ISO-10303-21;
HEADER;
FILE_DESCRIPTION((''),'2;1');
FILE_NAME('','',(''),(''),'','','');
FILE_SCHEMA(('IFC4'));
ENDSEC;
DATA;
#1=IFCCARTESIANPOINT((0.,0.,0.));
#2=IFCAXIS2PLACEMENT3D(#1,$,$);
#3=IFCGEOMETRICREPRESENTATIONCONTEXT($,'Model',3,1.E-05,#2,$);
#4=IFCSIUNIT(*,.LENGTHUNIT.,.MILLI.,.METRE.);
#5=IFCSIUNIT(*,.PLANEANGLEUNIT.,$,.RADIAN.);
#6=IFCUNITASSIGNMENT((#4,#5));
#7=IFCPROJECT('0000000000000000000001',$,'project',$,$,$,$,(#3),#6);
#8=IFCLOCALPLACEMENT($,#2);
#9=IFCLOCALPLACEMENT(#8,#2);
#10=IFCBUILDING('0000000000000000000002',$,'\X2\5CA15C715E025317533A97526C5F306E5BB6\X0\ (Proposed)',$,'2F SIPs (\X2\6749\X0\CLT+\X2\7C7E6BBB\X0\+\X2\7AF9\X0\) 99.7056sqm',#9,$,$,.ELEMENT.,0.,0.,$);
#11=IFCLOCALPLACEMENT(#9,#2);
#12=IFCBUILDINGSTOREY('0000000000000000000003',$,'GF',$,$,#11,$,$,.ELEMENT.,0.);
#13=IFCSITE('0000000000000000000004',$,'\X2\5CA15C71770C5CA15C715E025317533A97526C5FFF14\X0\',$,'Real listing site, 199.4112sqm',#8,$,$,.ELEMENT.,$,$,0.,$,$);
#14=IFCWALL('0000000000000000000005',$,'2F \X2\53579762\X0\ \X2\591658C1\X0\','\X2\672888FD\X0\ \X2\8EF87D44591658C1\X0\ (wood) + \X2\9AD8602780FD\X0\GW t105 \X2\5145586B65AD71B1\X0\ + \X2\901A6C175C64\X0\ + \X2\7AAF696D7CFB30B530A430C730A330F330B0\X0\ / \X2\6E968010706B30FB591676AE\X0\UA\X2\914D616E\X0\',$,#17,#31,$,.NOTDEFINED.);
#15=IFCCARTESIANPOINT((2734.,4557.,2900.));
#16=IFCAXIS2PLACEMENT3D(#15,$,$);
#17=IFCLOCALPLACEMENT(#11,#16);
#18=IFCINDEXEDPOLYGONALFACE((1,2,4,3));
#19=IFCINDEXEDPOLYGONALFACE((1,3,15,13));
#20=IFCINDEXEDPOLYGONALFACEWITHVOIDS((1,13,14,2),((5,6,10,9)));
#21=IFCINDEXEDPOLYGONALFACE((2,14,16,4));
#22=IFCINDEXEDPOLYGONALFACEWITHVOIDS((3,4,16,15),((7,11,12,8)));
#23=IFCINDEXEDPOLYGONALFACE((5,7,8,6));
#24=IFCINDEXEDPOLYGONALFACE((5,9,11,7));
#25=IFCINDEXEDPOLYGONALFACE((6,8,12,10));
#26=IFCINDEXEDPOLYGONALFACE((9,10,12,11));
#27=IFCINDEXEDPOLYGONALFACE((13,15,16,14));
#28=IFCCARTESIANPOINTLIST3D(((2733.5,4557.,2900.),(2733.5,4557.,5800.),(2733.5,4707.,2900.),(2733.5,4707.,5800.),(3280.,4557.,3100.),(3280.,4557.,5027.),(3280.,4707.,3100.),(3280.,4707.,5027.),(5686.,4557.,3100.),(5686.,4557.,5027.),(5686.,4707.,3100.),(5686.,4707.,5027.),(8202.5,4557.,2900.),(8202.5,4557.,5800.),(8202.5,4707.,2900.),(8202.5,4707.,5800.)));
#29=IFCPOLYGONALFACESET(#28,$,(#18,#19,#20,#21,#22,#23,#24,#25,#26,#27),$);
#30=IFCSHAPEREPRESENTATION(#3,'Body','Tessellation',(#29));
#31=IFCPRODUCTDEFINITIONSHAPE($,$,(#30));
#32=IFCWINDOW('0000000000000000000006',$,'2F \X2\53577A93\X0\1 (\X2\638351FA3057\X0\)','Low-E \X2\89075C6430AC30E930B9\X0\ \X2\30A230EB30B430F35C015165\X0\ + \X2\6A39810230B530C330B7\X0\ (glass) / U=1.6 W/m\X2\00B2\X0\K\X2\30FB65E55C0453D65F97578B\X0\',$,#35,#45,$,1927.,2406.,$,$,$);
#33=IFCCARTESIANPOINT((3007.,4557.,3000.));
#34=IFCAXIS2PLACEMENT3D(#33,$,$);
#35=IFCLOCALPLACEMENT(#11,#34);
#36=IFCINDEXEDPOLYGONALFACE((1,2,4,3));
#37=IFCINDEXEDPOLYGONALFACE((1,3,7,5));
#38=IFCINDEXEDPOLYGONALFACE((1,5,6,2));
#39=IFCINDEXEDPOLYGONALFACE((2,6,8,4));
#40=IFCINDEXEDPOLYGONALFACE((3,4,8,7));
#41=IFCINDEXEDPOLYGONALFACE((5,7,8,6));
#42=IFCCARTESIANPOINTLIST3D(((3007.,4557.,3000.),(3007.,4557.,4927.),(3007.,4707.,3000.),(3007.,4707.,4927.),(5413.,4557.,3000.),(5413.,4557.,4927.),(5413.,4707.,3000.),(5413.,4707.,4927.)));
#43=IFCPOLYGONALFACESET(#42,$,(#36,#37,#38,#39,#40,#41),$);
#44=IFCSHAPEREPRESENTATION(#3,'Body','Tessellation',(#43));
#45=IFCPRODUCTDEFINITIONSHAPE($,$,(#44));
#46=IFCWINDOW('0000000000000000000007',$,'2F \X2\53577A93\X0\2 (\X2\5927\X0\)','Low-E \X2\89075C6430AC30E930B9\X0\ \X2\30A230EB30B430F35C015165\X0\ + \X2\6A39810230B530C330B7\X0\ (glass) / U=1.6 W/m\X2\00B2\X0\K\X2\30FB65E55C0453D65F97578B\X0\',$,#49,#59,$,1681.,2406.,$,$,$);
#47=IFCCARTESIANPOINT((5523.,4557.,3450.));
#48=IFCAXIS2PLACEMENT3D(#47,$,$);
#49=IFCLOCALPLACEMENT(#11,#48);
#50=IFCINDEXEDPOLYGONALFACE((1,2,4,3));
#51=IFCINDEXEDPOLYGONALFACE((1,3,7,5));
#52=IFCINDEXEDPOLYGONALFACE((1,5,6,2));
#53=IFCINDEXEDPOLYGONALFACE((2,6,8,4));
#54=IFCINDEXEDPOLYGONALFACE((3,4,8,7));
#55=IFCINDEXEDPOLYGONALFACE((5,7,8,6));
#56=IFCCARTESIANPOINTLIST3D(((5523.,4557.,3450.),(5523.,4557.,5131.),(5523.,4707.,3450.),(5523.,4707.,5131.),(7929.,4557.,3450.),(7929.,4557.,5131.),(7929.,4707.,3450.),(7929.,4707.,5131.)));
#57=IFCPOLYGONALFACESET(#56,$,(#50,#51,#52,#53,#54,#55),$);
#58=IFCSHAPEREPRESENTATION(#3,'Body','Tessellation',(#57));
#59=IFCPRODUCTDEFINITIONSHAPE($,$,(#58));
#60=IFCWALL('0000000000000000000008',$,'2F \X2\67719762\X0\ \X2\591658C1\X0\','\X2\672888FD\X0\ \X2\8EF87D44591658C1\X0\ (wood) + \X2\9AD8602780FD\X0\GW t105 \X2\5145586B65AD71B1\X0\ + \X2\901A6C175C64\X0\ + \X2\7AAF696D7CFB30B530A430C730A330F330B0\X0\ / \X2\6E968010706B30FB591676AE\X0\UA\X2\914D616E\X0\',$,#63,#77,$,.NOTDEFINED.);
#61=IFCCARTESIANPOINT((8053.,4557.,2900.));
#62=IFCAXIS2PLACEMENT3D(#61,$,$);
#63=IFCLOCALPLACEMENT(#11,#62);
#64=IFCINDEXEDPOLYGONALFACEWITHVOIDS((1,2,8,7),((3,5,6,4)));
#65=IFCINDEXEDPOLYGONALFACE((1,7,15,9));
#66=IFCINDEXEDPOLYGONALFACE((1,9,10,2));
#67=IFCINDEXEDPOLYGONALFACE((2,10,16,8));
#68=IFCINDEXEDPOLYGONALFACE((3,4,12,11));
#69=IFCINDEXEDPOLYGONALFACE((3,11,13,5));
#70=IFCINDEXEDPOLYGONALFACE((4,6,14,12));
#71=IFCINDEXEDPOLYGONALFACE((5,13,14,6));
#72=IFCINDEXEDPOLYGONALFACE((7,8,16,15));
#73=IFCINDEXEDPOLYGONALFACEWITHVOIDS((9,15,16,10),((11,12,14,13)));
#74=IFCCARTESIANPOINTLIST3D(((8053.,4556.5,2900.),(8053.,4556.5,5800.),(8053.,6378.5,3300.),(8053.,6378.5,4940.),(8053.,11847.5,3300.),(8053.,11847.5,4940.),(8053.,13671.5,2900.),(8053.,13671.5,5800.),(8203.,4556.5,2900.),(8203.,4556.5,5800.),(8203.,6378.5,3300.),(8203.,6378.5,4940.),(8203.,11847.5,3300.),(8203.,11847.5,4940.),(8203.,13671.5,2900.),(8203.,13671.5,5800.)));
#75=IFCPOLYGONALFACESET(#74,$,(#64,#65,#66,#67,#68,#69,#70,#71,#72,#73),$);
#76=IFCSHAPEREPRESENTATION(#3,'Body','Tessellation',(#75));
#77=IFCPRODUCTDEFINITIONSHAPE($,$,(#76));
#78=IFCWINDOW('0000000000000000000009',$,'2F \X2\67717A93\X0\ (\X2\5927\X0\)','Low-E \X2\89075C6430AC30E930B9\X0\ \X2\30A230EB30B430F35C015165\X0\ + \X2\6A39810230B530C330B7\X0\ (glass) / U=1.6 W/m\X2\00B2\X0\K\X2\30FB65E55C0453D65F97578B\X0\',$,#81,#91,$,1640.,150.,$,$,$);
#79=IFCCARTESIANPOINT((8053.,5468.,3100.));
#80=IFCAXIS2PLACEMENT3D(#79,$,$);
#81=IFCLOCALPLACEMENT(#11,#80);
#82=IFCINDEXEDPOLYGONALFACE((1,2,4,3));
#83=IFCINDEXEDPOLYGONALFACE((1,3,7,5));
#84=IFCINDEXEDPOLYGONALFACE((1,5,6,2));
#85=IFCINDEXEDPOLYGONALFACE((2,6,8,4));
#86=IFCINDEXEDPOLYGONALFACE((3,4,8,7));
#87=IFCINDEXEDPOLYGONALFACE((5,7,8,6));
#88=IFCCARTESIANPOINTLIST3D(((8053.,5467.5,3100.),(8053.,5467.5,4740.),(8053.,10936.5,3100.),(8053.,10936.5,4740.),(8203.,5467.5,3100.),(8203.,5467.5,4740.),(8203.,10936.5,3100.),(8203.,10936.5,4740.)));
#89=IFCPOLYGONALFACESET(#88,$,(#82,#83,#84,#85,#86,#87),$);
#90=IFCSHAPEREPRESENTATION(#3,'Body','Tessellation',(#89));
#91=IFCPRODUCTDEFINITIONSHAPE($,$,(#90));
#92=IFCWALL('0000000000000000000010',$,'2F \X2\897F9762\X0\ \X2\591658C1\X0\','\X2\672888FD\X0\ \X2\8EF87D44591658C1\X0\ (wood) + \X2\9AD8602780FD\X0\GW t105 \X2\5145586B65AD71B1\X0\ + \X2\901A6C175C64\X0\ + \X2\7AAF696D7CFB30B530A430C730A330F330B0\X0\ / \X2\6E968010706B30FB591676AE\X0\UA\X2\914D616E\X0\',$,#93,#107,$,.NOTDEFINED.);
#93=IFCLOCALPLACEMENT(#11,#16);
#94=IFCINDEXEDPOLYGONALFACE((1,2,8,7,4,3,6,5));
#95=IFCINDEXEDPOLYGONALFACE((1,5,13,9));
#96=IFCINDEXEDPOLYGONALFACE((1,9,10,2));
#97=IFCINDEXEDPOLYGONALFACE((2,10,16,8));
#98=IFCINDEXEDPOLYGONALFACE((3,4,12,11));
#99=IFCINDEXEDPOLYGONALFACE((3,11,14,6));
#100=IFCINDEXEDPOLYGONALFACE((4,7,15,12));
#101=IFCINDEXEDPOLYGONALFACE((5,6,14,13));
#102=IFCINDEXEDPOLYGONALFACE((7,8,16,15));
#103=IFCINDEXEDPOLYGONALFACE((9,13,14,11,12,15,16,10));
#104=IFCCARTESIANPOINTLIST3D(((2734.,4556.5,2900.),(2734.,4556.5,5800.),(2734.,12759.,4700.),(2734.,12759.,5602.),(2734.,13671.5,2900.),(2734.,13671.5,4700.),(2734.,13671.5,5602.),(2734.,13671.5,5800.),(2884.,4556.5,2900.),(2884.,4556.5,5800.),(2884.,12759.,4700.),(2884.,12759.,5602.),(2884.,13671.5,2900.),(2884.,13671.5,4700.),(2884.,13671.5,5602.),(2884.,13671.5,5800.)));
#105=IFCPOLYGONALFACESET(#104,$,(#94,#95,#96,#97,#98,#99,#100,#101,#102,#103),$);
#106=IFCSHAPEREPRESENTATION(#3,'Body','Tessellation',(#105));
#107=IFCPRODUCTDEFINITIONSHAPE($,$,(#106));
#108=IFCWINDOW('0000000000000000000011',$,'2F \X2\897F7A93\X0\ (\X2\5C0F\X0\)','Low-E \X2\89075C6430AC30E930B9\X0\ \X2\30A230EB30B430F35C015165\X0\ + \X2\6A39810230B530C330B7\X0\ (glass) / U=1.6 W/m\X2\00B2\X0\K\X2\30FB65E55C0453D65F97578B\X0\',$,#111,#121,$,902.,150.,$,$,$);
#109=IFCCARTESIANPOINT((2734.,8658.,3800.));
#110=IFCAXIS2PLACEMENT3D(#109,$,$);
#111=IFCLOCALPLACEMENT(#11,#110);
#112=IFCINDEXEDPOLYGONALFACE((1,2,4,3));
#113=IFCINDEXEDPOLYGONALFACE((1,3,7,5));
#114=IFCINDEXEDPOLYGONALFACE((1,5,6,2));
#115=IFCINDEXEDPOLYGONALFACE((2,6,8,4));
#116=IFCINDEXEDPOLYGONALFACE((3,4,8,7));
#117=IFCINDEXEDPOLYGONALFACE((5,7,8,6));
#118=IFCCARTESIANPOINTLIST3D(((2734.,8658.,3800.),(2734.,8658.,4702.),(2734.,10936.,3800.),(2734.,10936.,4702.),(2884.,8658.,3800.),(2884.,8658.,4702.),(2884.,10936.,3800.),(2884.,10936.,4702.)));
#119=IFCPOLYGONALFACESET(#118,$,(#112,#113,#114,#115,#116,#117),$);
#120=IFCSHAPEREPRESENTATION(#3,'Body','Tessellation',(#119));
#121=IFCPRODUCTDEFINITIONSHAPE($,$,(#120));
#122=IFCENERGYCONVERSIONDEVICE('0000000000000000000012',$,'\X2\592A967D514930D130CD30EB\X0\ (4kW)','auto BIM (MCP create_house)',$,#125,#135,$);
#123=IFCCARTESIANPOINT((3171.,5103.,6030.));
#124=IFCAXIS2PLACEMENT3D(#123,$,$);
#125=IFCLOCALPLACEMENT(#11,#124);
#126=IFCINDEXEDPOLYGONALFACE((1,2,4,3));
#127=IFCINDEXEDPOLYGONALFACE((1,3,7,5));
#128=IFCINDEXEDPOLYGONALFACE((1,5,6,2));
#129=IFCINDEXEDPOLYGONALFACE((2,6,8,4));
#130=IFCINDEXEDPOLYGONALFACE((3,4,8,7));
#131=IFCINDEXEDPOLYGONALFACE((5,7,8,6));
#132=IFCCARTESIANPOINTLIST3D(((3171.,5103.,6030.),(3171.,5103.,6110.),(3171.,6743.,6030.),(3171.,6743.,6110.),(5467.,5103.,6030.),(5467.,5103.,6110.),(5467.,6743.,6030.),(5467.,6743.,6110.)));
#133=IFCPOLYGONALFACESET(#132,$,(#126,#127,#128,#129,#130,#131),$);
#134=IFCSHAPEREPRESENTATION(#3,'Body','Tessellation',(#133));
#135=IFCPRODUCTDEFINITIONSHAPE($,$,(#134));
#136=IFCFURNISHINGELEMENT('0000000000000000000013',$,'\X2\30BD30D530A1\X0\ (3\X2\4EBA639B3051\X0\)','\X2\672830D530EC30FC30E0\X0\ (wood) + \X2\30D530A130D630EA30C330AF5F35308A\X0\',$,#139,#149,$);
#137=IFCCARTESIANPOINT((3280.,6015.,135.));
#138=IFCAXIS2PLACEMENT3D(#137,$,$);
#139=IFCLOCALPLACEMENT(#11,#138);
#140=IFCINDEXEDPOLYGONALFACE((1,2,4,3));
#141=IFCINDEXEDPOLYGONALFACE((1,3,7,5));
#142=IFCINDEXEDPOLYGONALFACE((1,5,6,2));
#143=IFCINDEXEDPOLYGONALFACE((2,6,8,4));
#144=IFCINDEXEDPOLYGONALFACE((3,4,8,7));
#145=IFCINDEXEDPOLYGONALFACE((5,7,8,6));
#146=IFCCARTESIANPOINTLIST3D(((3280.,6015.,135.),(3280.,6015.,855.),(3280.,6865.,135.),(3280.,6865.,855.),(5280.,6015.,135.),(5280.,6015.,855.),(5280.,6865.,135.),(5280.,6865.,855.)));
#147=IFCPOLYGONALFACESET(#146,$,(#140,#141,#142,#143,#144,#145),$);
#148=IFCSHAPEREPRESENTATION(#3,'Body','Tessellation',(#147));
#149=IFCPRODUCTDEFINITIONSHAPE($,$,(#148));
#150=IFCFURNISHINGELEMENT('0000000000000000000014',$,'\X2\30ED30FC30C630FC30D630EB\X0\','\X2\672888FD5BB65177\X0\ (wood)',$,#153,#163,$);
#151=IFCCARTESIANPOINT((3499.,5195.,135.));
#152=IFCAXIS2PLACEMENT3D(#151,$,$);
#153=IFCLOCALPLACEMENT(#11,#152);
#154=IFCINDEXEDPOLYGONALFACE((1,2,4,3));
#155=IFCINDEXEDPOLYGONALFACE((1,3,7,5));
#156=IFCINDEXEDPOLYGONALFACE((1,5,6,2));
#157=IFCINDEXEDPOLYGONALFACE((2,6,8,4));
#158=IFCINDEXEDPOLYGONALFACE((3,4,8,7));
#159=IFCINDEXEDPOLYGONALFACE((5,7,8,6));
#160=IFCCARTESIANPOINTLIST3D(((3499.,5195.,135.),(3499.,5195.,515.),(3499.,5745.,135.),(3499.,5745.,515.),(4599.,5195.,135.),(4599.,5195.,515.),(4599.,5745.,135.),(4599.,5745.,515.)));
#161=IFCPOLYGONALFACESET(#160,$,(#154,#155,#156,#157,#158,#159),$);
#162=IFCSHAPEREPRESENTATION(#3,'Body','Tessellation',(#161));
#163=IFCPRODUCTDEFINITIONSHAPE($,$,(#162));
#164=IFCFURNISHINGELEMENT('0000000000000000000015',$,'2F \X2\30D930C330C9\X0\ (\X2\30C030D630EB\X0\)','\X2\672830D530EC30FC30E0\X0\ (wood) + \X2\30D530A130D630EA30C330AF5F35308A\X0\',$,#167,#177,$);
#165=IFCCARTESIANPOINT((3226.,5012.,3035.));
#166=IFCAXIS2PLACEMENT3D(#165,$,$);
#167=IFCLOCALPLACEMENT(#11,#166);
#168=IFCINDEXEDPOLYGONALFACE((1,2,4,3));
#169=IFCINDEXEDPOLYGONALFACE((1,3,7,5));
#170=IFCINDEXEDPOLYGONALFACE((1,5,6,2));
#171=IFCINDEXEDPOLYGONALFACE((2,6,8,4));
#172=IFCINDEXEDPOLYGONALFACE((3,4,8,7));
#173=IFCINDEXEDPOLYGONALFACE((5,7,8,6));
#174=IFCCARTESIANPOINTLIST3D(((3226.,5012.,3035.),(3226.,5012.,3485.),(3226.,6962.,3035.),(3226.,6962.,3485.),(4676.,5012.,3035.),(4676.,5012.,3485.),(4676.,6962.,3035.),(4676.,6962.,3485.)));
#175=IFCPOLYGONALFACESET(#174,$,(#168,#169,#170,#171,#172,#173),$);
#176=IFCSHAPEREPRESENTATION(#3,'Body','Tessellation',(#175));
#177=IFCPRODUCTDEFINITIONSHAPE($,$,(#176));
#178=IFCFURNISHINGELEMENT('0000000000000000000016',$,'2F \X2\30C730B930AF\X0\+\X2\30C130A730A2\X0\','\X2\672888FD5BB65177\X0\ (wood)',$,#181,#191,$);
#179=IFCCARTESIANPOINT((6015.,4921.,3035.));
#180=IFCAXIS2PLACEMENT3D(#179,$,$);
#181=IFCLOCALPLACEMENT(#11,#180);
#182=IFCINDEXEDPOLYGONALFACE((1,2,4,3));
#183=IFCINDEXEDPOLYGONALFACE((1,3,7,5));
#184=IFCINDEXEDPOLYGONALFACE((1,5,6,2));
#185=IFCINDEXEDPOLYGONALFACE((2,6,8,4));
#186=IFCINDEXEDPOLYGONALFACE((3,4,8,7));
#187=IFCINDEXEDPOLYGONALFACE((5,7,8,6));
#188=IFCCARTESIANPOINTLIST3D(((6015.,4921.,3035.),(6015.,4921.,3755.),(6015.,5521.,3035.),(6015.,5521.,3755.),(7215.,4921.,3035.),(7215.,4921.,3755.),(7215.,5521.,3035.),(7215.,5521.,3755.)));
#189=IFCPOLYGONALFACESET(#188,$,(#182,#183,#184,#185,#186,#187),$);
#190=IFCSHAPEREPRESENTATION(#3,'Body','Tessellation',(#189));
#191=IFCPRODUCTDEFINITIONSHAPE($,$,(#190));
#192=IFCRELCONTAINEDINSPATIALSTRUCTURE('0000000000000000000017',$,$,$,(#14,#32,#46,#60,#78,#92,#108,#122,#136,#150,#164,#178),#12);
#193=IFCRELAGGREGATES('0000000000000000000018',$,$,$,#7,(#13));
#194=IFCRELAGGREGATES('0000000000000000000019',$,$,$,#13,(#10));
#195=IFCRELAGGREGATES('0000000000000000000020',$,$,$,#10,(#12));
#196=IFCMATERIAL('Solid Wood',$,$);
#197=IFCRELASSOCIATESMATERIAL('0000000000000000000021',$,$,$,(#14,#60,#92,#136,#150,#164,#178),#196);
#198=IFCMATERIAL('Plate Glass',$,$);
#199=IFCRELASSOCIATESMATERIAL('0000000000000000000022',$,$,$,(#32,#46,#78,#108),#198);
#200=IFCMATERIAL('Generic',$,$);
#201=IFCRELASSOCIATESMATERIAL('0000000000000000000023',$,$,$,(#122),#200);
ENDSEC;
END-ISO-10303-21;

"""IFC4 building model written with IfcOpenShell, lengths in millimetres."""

from ifc_helpers import new_model, si_unit, frame, frame_2d, origin, place, context, project, spatial, rectangle, extrude, material, element, fill, save


model = new_model("IFC4")

# Units and contexts
model_context = context("Model", 3, precision=1e-05, world=origin())
ifc_project = project(units=[si_unit("LENGTHUNIT", "METRE", prefix="MILLI"), si_unit("PLANEANGLEUNIT", "RADIAN")], contexts=[model_context])

# Site, building, storey
site_placement = place(None, origin())
site = spatial("IfcSite", under=ifc_project, at=site_placement, Name="岡山県岡山市北区青江４", ObjectType="Real listing site, 199.4112sqm", CompositionType="ELEMENT", RefElevation=0.0)
building_placement = place(site_placement, origin())
building = spatial("IfcBuilding", under=site, at=building_placement, Name="岡山市北区青江の家 (Proposed)", ObjectType="2F SIPs (杉CLT+籾殻+竹) 99.7056sqm", CompositionType="ELEMENT", ElevationOfRefHeight=0.0, ElevationOfTerrain=0.0)
storey_placement = place(building_placement, origin())
storey = spatial("IfcBuildingStorey", under=building, at=storey_placement, Name="GF", CompositionType="ELEMENT", Elevation=0.0)

# Shared definitions
ifc_material_1 = material(Name="Solid Wood")

# Wall, openings, windows
wall_1_placement = place(storey_placement, frame((2734.0, 4557.0, 2900.0)))
wall_1 = element("IfcWall", 1, at=wall_1_placement, inside=storey, material=ifc_material_1, Name="2F 南面 外壁", Description="木製 軸組外壁 (wood) + 高性能GW t105 充填断熱 + 通気層 + 窯業系サイディング / 準耐火・外皮UA配慮", PredefinedType="NOTDEFINED", context=model_context, shape_type="SweptSolid", body=[
    extrude(rectangle(XDim=5469.0, YDim=150.0, at=frame_2d((2734.0, 75.0))), frame((2734.0, 4557.0, 2900.0)), (0.0, 0.0, 1.0), 2900.0),
])
opening_1_placement = place(storey_placement, frame((3007.0, 4557.0, 3000.0)))
opening_1 = element("IfcOpeningElement", 2, at=opening_1_placement, cuts=wall_1, PredefinedType="NOTDEFINED", context=model_context, shape_type="SweptSolid", body=[
    extrude(rectangle(XDim=2406.0, YDim=150.0, at=frame_2d((1203.0, 75.0))), frame((3007.0, 4557.0, 3000.0)), (0.0, 0.0, 1.0), 1927.0),
])
opening_2_placement = place(storey_placement, frame((5523.0, 4557.0, 3450.0)))
opening_2 = element("IfcOpeningElement", 3, at=opening_2_placement, cuts=wall_1, PredefinedType="NOTDEFINED", context=model_context, shape_type="SweptSolid", body=[
    extrude(rectangle(XDim=2406.0, YDim=150.0, at=frame_2d((1203.0, 75.0))), frame((5523.0, 4557.0, 3450.0)), (0.0, 0.0, 1.0), 1681.0),
])
ifc_material_2 = material(Name="Plate Glass")
window_1_placement = place(storey_placement, frame((3007.0, 4557.0, 3000.0)))
window_1 = element("IfcWindow", 4, at=window_1_placement, inside=storey, material=ifc_material_2, Name="2F 南窓1 (掃出し)", Description="Low-E 複層ガラス アルゴン封入 + 樹脂サッシ (glass) / U=1.6 W/m²K・日射取得型", OverallHeight=1927.0, OverallWidth=2406.0, context=model_context, shape_type="SweptSolid", body=[
    extrude(rectangle(XDim=2406.0, YDim=150.0, at=frame_2d((1203.0, 75.0))), frame((3007.0, 4557.0, 3000.0)), (0.0, 0.0, 1.0), 1927.0),
])
fill(opening_1, window_1)
window_2_placement = place(storey_placement, frame((5523.0, 4557.0, 3450.0)))
window_2 = element("IfcWindow", 5, at=window_2_placement, inside=storey, material=ifc_material_2, Name="2F 南窓2 (大)", Description="Low-E 複層ガラス アルゴン封入 + 樹脂サッシ (glass) / U=1.6 W/m²K・日射取得型", OverallHeight=1681.0, OverallWidth=2406.0, context=model_context, shape_type="SweptSolid", body=[
    extrude(rectangle(XDim=2406.0, YDim=150.0, at=frame_2d((1203.0, 75.0))), frame((5523.0, 4557.0, 3450.0)), (0.0, 0.0, 1.0), 1681.0),
])
fill(opening_2, window_2)

# Walls, openings, windows
wall_2_placement = place(storey_placement, frame((8053.0, 4557.0, 2900.0)))
wall_2 = element("IfcWall", 6, at=wall_2_placement, inside=storey, material=ifc_material_1, Name="2F 東面 外壁", Description="木製 軸組外壁 (wood) + 高性能GW t105 充填断熱 + 通気層 + 窯業系サイディング / 準耐火・外皮UA配慮", PredefinedType="NOTDEFINED", context=model_context, shape_type="SweptSolid", body=[
    extrude(rectangle(XDim=150.0, YDim=9115.0, at=frame_2d((75.0, 4557.0))), frame((8053.0, 4557.0, 2900.0)), (0.0, 0.0, 1.0), 2900.0),
])
opening_3_placement = place(storey_placement, frame((8053.0, 5468.0, 3100.0)))
opening_3 = element("IfcOpeningElement", 7, at=opening_3_placement, cuts=wall_2, PredefinedType="NOTDEFINED", context=model_context, shape_type="SweptSolid", body=[
    extrude(rectangle(XDim=150.0, YDim=5469.0, at=frame_2d((75.0, 2734.0))), frame((8053.0, 5468.0, 3100.0)), (0.0, 0.0, 1.0), 1640.0),
])
window_3_placement = place(storey_placement, frame((8053.0, 5468.0, 3100.0)))
window_3 = element("IfcWindow", 8, at=window_3_placement, inside=storey, material=ifc_material_2, Name="2F 東窓 (大)", Description="Low-E 複層ガラス アルゴン封入 + 樹脂サッシ (glass) / U=1.6 W/m²K・日射取得型", OverallHeight=1640.0, OverallWidth=150.0, context=model_context, shape_type="SweptSolid", body=[
    extrude(rectangle(XDim=150.0, YDim=5469.0, at=frame_2d((75.0, 2734.0))), frame((8053.0, 5468.0, 3100.0)), (0.0, 0.0, 1.0), 1640.0),
])
fill(opening_3, window_3)
wall_3_placement = place(storey_placement, frame((2734.0, 4557.0, 2900.0)))
wall_3 = element("IfcWall", 9, at=wall_3_placement, inside=storey, material=ifc_material_1, Name="2F 西面 外壁", Description="木製 軸組外壁 (wood) + 高性能GW t105 充填断熱 + 通気層 + 窯業系サイディング / 準耐火・外皮UA配慮", PredefinedType="NOTDEFINED", context=model_context, shape_type="SweptSolid", body=[
    extrude(rectangle(XDim=150.0, YDim=9115.0, at=frame_2d((75.0, 4557.0))), frame((2734.0, 4557.0, 2900.0)), (0.0, 0.0, 1.0), 2900.0),
])
opening_4_placement = place(storey_placement, frame((2734.0, 8658.0, 3800.0)))
opening_4 = element("IfcOpeningElement", 10, at=opening_4_placement, cuts=wall_3, PredefinedType="NOTDEFINED", context=model_context, shape_type="SweptSolid", body=[
    extrude(rectangle(XDim=150.0, YDim=2278.0, at=frame_2d((75.0, 1139.0))), frame((2734.0, 8658.0, 3800.0)), (0.0, 0.0, 1.0), 902.0),
])
window_4_placement = place(storey_placement, frame((2734.0, 8658.0, 3800.0)))
window_4 = element("IfcWindow", 11, at=window_4_placement, inside=storey, material=ifc_material_2, Name="2F 西窓 (小)", Description="Low-E 複層ガラス アルゴン封入 + 樹脂サッシ (glass) / U=1.6 W/m²K・日射取得型", OverallHeight=902.0, OverallWidth=150.0, context=model_context, shape_type="SweptSolid", body=[
    extrude(rectangle(XDim=150.0, YDim=2278.0, at=frame_2d((75.0, 1139.0))), frame((2734.0, 8658.0, 3800.0)), (0.0, 0.0, 1.0), 902.0),
])
fill(opening_4, window_4)

# Shared definitions
ifc_material_3 = material(Name="Generic")

# Energy conversion device
energy_conversion_device_placement = place(storey_placement, frame((3171.0, 5103.0, 6030.0)))
element("IfcEnergyConversionDevice", 12, at=energy_conversion_device_placement, inside=storey, material=ifc_material_3, Name="太陽光パネル (4kW)", Description="auto BIM (MCP create_house)", context=model_context, shape_type="SweptSolid", body=[
    extrude(rectangle(XDim=2296.0, YDim=1640.0, at=frame_2d((1148.0, 820.0))), frame((3171.0, 5103.0, 6030.0)), (0.0, 0.0, 1.0), 80.0),
])

# Furnishing elements
furnishing_1_placement = place(storey_placement, frame((3280.0, 6015.0, 135.0)))
element("IfcFurnishingElement", 13, at=furnishing_1_placement, inside=storey, material=ifc_material_1, Name="ソファ (3人掛け)", Description="木フレーム (wood) + ファブリック張り", context=model_context, shape_type="SweptSolid", body=[
    extrude(rectangle(XDim=2000.0, YDim=850.0, at=frame_2d((1000.0, 425.0))), frame((3280.0, 6015.0, 135.0)), (0.0, 0.0, 1.0), 720.0),
])
furnishing_2_placement = place(storey_placement, frame((3499.0, 5195.0, 135.0)))
element("IfcFurnishingElement", 14, at=furnishing_2_placement, inside=storey, material=ifc_material_1, Name="ローテーブル", Description="木製家具 (wood)", context=model_context, shape_type="SweptSolid", body=[
    extrude(rectangle(XDim=1100.0, YDim=550.0, at=frame_2d((550.0, 275.0))), frame((3499.0, 5195.0, 135.0)), (0.0, 0.0, 1.0), 380.0),
])
furnishing_3_placement = place(storey_placement, frame((3226.0, 5012.0, 3035.0)))
element("IfcFurnishingElement", 15, at=furnishing_3_placement, inside=storey, material=ifc_material_1, Name="2F ベッド (ダブル)", Description="木フレーム (wood) + ファブリック張り", context=model_context, shape_type="SweptSolid", body=[
    extrude(rectangle(XDim=1450.0, YDim=1950.0, at=frame_2d((725.0, 975.0))), frame((3226.0, 5012.0, 3035.0)), (0.0, 0.0, 1.0), 450.0),
])
furnishing_4_placement = place(storey_placement, frame((6015.0, 4921.0, 3035.0)))
element("IfcFurnishingElement", 16, at=furnishing_4_placement, inside=storey, material=ifc_material_1, Name="2F デスク+チェア", Description="木製家具 (wood)", context=model_context, shape_type="SweptSolid", body=[
    extrude(rectangle(XDim=1200.0, YDim=600.0, at=frame_2d((600.0, 300.0))), frame((6015.0, 4921.0, 3035.0)), (0.0, 0.0, 1.0), 720.0),
])

save(model, "model.ifc")
